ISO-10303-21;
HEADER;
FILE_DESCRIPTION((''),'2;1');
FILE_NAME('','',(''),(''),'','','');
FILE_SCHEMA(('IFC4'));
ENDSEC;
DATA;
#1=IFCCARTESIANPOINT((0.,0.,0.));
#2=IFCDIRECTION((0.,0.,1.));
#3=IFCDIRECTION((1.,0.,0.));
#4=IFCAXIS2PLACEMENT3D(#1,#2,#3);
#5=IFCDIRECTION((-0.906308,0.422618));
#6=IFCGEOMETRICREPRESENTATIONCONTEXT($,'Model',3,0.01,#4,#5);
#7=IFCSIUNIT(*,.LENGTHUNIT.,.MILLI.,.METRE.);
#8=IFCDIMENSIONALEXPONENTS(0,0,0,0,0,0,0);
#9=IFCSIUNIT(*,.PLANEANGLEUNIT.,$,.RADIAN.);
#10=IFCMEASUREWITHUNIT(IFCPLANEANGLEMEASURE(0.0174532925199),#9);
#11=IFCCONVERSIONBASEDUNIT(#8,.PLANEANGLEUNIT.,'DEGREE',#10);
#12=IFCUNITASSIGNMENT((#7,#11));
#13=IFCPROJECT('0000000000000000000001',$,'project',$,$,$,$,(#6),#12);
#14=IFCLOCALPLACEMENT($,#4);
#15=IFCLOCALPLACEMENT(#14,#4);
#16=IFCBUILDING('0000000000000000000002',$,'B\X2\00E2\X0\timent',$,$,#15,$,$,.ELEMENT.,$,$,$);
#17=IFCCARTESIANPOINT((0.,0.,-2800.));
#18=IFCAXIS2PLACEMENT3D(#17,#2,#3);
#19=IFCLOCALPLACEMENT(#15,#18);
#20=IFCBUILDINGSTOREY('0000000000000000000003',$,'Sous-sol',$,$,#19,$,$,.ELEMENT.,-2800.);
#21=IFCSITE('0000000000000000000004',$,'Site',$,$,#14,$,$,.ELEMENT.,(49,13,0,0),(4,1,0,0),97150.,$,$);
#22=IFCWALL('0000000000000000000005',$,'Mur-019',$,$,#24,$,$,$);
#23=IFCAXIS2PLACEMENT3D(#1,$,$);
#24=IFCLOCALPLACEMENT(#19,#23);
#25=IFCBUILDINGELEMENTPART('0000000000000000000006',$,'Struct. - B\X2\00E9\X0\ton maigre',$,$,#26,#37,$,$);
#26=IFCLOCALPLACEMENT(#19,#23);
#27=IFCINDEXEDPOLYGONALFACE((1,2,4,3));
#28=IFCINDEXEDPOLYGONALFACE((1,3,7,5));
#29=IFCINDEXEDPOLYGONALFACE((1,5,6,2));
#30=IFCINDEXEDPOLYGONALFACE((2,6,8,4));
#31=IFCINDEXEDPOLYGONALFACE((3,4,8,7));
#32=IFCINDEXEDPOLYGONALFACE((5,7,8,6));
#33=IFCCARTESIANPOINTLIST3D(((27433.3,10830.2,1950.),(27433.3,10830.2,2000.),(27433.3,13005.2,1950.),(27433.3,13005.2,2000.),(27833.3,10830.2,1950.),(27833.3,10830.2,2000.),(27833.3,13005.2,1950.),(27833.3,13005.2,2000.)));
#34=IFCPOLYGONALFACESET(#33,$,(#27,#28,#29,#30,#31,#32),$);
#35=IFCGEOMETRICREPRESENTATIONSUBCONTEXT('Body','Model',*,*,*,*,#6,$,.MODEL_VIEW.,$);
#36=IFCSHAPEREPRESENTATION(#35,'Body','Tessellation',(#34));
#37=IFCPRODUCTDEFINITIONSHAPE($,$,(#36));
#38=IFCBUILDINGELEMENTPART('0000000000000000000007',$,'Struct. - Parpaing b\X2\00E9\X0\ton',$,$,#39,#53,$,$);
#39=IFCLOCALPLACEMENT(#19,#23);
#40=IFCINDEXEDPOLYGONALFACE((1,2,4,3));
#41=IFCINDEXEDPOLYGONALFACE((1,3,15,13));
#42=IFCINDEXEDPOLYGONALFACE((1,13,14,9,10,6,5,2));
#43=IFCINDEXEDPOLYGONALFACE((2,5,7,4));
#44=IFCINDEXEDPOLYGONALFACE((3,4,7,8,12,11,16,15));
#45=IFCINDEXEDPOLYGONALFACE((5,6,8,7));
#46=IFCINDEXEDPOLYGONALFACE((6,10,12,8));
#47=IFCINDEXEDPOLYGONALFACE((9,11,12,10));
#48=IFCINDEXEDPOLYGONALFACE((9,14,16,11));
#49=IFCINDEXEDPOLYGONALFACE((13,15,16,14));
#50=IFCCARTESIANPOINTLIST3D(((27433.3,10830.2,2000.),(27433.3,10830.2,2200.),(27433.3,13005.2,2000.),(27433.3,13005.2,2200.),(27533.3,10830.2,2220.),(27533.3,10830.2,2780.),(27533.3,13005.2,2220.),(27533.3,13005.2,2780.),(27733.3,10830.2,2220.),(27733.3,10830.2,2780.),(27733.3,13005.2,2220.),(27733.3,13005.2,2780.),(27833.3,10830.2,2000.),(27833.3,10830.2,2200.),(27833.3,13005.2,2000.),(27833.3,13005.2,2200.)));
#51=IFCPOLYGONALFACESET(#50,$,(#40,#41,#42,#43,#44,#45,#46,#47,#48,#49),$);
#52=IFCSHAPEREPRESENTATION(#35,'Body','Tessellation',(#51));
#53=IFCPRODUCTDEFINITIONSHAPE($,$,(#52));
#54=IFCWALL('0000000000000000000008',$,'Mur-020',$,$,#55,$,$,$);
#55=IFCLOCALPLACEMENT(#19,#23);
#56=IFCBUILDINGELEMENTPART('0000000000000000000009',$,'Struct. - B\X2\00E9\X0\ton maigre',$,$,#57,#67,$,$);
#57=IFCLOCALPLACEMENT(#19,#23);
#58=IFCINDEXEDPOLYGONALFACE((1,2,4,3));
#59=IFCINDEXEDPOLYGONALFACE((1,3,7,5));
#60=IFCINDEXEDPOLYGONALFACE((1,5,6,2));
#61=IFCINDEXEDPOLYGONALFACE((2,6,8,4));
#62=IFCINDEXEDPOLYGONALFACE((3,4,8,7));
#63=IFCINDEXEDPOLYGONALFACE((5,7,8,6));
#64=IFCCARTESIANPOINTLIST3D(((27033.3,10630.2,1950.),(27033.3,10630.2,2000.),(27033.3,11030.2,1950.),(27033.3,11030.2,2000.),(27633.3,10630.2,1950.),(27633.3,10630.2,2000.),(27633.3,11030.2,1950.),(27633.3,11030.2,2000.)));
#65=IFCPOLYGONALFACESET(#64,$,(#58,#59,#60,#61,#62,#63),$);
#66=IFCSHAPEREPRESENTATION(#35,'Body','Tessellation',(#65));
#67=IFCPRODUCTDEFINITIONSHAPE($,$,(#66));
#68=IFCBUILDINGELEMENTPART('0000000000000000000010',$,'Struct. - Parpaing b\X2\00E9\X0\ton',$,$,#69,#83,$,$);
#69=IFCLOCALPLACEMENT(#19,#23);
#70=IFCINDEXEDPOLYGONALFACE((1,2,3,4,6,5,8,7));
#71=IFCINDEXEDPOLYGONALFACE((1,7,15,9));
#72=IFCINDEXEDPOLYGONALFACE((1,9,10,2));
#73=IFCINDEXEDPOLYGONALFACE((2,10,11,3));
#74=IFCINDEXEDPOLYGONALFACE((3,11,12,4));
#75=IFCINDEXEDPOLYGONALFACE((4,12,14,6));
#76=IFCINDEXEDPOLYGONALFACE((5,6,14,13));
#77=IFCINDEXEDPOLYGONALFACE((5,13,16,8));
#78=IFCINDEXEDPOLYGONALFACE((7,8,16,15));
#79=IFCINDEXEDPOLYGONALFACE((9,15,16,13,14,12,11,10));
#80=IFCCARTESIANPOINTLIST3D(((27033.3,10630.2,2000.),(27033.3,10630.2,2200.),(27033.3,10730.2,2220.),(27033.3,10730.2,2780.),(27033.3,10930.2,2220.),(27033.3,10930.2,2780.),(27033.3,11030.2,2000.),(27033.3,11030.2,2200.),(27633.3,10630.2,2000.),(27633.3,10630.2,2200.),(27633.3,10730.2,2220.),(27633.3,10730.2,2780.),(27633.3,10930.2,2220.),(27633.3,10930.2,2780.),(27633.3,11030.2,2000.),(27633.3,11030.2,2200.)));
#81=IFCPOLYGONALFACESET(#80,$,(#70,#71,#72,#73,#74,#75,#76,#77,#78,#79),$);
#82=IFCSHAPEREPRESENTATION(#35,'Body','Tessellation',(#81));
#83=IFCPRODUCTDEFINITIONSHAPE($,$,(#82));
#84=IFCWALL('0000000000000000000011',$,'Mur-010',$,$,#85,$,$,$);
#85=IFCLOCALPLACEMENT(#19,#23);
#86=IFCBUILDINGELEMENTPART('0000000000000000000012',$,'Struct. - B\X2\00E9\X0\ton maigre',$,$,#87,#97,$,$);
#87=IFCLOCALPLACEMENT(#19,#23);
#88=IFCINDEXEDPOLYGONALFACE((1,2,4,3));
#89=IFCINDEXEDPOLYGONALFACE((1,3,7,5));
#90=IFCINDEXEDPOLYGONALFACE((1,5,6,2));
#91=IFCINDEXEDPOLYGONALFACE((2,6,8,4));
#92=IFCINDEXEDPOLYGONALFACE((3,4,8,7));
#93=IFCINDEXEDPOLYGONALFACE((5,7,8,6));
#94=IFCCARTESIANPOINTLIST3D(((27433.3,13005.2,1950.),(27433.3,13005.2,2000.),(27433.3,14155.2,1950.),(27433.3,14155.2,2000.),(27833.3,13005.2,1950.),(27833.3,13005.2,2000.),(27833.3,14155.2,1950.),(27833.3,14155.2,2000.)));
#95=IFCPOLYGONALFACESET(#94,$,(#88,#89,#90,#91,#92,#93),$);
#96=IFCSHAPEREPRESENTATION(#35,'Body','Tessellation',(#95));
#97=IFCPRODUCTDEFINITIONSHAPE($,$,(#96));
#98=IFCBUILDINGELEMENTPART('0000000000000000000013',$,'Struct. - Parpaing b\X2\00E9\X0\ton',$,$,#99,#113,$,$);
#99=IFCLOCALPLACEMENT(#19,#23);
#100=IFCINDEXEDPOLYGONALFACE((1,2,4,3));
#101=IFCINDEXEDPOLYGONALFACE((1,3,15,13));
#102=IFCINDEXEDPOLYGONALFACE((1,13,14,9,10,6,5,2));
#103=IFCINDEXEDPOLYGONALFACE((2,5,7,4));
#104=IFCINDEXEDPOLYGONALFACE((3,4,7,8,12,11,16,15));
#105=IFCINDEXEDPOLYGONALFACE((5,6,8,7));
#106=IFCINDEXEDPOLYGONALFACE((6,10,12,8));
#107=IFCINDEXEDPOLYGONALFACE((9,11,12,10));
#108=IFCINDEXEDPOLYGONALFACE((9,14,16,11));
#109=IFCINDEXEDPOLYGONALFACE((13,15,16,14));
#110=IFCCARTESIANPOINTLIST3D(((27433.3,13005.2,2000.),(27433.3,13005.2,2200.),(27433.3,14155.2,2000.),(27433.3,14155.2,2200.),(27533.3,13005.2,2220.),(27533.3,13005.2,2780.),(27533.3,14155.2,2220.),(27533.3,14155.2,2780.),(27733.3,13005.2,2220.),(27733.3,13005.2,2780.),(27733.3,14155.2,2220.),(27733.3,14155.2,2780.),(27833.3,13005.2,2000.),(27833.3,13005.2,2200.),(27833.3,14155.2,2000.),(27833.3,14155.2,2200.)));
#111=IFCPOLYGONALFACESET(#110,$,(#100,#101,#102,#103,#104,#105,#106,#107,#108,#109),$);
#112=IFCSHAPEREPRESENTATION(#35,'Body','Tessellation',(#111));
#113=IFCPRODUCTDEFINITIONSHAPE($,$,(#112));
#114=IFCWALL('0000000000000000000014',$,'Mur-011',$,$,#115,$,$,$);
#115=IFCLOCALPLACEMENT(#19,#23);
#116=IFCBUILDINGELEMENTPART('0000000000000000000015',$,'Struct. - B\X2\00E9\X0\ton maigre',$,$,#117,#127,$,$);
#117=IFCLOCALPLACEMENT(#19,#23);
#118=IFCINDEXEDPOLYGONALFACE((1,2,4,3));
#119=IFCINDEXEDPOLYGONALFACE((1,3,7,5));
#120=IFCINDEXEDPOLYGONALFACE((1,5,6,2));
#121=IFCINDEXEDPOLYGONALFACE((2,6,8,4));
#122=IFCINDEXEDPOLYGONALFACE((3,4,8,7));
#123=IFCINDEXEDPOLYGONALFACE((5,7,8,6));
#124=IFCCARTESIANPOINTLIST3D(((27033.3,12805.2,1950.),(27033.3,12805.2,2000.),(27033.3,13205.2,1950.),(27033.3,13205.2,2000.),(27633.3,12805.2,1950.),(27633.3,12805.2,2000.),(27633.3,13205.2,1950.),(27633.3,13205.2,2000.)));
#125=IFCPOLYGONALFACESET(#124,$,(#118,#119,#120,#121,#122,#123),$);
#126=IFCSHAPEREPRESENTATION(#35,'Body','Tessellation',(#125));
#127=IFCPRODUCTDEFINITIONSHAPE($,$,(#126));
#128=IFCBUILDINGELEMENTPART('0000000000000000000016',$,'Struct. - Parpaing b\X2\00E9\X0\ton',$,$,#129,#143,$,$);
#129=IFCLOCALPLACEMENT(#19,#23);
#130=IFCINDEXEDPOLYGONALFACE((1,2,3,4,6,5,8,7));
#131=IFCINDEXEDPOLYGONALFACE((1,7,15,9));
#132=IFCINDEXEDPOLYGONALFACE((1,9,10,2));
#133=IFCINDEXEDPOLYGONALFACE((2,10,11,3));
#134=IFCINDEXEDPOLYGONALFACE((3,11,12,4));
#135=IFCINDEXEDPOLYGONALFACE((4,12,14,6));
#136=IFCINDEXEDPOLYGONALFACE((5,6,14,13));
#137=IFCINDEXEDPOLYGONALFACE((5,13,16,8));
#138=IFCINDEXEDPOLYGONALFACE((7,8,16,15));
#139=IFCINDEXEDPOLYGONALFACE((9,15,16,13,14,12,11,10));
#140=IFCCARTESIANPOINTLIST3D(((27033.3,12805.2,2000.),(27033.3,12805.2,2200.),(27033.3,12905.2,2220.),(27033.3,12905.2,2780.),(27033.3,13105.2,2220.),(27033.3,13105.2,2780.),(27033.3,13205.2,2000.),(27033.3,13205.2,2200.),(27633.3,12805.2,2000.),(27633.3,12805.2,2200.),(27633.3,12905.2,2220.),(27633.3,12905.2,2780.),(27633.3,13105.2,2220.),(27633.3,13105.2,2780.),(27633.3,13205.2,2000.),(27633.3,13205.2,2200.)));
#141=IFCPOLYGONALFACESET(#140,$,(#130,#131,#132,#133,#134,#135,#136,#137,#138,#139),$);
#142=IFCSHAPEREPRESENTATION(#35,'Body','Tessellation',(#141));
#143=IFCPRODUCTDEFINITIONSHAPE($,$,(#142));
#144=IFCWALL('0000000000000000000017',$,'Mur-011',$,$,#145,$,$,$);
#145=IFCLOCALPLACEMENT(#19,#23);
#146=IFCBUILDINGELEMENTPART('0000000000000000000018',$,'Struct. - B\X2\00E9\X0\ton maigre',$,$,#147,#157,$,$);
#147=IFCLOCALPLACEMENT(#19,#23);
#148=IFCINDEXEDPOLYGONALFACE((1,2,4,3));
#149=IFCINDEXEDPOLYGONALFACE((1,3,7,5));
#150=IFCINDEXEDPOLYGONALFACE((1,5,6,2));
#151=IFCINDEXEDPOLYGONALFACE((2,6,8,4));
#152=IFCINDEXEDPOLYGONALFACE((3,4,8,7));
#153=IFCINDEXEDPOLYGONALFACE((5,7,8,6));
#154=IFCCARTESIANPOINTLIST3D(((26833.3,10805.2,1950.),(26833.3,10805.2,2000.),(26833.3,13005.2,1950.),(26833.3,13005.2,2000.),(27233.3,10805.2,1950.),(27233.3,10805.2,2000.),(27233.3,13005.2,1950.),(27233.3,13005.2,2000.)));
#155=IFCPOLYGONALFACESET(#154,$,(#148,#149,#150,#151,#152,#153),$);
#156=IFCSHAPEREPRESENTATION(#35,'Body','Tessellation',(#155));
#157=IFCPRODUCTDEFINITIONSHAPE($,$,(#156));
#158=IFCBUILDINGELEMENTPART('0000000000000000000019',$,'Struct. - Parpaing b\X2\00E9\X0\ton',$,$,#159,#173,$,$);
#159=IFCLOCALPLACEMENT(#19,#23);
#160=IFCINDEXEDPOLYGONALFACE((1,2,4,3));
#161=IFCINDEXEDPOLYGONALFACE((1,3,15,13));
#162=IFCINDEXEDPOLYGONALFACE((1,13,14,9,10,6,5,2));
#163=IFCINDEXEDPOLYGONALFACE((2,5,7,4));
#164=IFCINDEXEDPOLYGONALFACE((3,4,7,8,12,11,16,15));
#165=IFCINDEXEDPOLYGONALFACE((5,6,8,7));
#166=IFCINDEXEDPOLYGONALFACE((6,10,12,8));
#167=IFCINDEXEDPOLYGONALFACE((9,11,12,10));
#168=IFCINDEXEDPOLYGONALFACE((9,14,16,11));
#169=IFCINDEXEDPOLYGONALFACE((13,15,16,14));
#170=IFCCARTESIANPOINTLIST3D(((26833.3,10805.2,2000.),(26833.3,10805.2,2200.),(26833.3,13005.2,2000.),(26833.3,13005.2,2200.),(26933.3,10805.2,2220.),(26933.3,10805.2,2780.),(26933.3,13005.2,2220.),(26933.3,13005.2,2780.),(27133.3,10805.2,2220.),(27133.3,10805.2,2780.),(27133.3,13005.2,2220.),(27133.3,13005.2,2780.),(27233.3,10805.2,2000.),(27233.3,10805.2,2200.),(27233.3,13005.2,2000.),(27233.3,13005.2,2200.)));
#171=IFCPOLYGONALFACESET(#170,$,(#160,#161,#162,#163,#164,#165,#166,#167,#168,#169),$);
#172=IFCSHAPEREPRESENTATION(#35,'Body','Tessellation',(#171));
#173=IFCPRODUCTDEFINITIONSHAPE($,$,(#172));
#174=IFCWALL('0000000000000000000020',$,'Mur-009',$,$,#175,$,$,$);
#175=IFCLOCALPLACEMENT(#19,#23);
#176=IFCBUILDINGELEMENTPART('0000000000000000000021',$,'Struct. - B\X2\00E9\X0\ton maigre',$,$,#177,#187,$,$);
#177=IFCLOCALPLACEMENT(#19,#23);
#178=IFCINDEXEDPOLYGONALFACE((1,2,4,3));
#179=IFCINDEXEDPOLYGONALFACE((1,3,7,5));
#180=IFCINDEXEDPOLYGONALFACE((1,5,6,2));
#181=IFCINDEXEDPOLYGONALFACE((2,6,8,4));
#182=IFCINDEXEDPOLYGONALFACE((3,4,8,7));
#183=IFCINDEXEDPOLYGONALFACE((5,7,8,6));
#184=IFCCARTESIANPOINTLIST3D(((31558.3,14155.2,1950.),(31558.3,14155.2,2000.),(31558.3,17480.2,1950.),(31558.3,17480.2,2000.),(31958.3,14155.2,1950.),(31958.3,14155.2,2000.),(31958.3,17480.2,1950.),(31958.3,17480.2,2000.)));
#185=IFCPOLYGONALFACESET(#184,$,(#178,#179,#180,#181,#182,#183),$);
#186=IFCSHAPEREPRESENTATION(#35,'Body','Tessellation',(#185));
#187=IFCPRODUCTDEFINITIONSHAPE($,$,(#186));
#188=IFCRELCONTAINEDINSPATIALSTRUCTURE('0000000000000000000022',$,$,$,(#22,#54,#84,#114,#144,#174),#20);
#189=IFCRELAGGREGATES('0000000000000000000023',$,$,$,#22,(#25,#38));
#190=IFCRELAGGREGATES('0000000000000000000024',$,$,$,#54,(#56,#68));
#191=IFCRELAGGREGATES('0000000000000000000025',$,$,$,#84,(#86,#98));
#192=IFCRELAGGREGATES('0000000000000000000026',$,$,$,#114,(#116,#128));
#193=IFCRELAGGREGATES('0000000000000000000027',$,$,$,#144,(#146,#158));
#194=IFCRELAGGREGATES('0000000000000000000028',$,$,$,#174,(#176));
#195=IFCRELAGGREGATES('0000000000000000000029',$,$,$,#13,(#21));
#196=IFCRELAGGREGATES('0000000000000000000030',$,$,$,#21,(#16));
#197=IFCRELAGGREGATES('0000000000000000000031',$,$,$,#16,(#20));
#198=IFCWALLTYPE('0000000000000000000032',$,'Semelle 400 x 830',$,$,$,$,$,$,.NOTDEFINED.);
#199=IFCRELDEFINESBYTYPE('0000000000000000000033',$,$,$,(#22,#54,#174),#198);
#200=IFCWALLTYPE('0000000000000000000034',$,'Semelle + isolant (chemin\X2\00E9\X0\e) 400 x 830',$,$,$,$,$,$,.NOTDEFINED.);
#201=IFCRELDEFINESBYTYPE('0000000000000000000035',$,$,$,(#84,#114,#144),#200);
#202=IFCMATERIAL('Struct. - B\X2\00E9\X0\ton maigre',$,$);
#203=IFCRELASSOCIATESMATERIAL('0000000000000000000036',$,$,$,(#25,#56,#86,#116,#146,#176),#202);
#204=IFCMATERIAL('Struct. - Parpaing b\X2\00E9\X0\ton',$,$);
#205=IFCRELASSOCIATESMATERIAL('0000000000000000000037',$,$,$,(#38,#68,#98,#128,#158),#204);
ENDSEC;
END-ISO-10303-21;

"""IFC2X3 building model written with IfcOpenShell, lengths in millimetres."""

from ifc_helpers import new_model, entity, si_unit, converted_unit, direction, frame, origin_with_axes, place, context, subcontext, project, spatial, polyline, outline, extrude, material, type_object, element, aggregate, save


model = new_model("IFC2X3")

# Units and contexts
model_context = context("Model", 3, precision=0.01, world=origin_with_axes(), true_north=direction((-0.906308, 0.422618)))
body_context = subcontext(model_context, "Body", "Model", "MODEL_VIEW")
ifc_project = project(units=[si_unit("LENGTHUNIT", "METRE", prefix="MILLI"), converted_unit("PLANEANGLEUNIT", "DEGREE", entity("IfcPlaneAngleMeasure", 0.0174532925199), si_unit("PLANEANGLEUNIT", "RADIAN"), dimensions=[0, 0, 0, 0, 0, 0, 0])], contexts=[model_context])

# Site, building, storey
site_placement = place(None, origin_with_axes())
site = spatial("IfcSite", under=ifc_project, at=site_placement, Name="Site", CompositionType="ELEMENT", RefLatitude=(49, 13, 0, 0), RefLongitude=(4, 1, 0, 0), RefElevation=97150.0)
building_placement = place(site_placement, origin_with_axes())
building = spatial("IfcBuilding", under=site, at=building_placement, Name="Bâtiment", CompositionType="ELEMENT")
storey_placement = place(building_placement, frame((0.0, 0.0, -2800.0), z_axis=(0.0, 0.0, 1.0), x_axis=(1.0, 0.0, 0.0)))
storey = spatial("IfcBuildingStorey", under=building, at=storey_placement, Name="Sous-sol", CompositionType="ELEMENT", Elevation=-2800.0)

# Walls, building element parts
wall_type_1 = type_object("IfcWallType", Name="Semelle 400 x 830", PredefinedType="NOTDEFINED")
wall_1_placement = place(storey_placement, frame((27633.3, 13005.2, 2000.0), z_axis=(0.0, 0.0, 1.0), x_axis=(0.0, -1.0, 0.0)))
wall_1 = element("IfcWall", 1, at=wall_1_placement, inside=storey, type_object=wall_type_1, Name="Mur-019")
ifc_material_1 = material(Name="Struct. - Béton maigre")
building_element_part_1_placement = place(wall_1_placement, origin_with_axes())
building_element_part_1 = element("IfcBuildingElementPart", 2, at=building_element_part_1_placement, material=ifc_material_1, Name="Struct. - Béton maigre", context=body_context, shape_type="SweptSolid", body=[
    extrude(outline(polyline([(-200.0, 0.0), (-200.0, -50.0), (200.0, -50.0), (200.0, 0.0), (-200.0, 0.0)])), frame((0.0, 0.0, 0.0), z_axis=(-1.0, 0.0, 0.0), x_axis=(0.0, -1.0, 0.0)), (0.0, 0.0, -1.0), 2175.0),
])
ifc_material_2 = material(Name="Struct. - Parpaing béton")
building_element_part_2_placement = place(wall_1_placement, origin_with_axes())
building_element_part_2 = element("IfcBuildingElementPart", 3, at=building_element_part_2_placement, material=ifc_material_2, Name="Struct. - Parpaing béton", context=body_context, shape_type="SweptSolid", body=[
    extrude(outline(polyline([(-200.0, 200.0), (-200.0, 0.0), (200.0, 0.0), (200.0, 200.0), (100.0, 220.0), (100.0, 780.0), (-100.0, 780.0), (-100.0, 220.0), (-200.0, 200.0)])), frame((0.0, 0.0, 0.0), z_axis=(-1.0, 0.0, 0.0), x_axis=(0.0, -1.0, 0.0)), (0.0, 0.0, -1.0), 2175.0),
])
aggregate(wall_1, [building_element_part_1, building_element_part_2])
wall_2_placement = place(storey_placement, frame((27633.3, 10830.2, 2000.0), z_axis=(0.0, 0.0, 1.0), x_axis=(-1.0, 0.0, 0.0)))
wall_2 = element("IfcWall", 4, at=wall_2_placement, inside=storey, type_object=wall_type_1, Name="Mur-020")
building_element_part_3_placement = place(wall_2_placement, origin_with_axes())
building_element_part_3 = element("IfcBuildingElementPart", 5, at=building_element_part_3_placement, material=ifc_material_1, Name="Struct. - Béton maigre", context=body_context, shape_type="SweptSolid", body=[
    extrude(outline(polyline([(-200.0, 0.0), (-200.0, -50.0), (200.0, -50.0), (200.0, 0.0), (-200.0, 0.0)])), frame((0.0, 0.0, 0.0), z_axis=(-1.0, 0.0, 0.0), x_axis=(0.0, -1.0, 0.0)), (0.0, 0.0, -1.0), 600.0),
])
building_element_part_4_placement = place(wall_2_placement, origin_with_axes())
building_element_part_4 = element("IfcBuildingElementPart", 6, at=building_element_part_4_placement, material=ifc_material_2, Name="Struct. - Parpaing béton", context=body_context, shape_type="SweptSolid", body=[
    extrude(outline(polyline([(-200.0, 200.0), (-200.0, 0.0), (200.0, 0.0), (200.0, 200.0), (100.0, 220.0), (100.0, 780.0), (-100.0, 780.0), (-100.0, 220.0), (-200.0, 200.0)])), frame((0.0, 0.0, 0.0), z_axis=(-1.0, 0.0, 0.0), x_axis=(0.0, -1.0, 0.0)), (0.0, 0.0, -1.0), 600.0),
])
aggregate(wall_2, [building_element_part_3, building_element_part_4])
wall_type_2 = type_object("IfcWallType", Name="Semelle + isolant (cheminée) 400 x 830", PredefinedType="NOTDEFINED")
wall_3_placement = place(storey_placement, frame((27633.3, 14155.2, 2000.0), z_axis=(0.0, 0.0, 1.0), x_axis=(0.0, -1.0, 0.0)))
wall_3 = element("IfcWall", 7, at=wall_3_placement, inside=storey, type_object=wall_type_2, Name="Mur-010")
building_element_part_5_placement = place(wall_3_placement, origin_with_axes())
building_element_part_5 = element("IfcBuildingElementPart", 8, at=building_element_part_5_placement, material=ifc_material_1, Name="Struct. - Béton maigre", context=body_context, shape_type="SweptSolid", body=[
    extrude(outline(polyline([(-200.0, 0.0), (-200.0, -50.0), (200.0, -50.0), (200.0, 0.0), (-200.0, 0.0)])), frame((0.0, 0.0, 0.0), z_axis=(-1.0, 0.0, 0.0), x_axis=(0.0, -1.0, 0.0)), (0.0, 0.0, -1.0), 1150.0),
])
building_element_part_6_placement = place(wall_3_placement, origin_with_axes())
building_element_part_6 = element("IfcBuildingElementPart", 9, at=building_element_part_6_placement, material=ifc_material_2, Name="Struct. - Parpaing béton", context=body_context, shape_type="SweptSolid", body=[
    extrude(outline(polyline([(-100.0, 220.0), (-200.0, 200.0), (-200.0, 0.0), (200.0, 0.0), (200.0, 200.0), (100.0, 220.0), (100.0, 780.0), (-100.0, 780.0), (-100.0, 220.0)])), frame((0.0, 0.0, 0.0), z_axis=(-1.0, 0.0, 0.0), x_axis=(0.0, -1.0, 0.0)), (0.0, 0.0, -1.0), 1150.0),
])
aggregate(wall_3, [building_element_part_5, building_element_part_6])
wall_4_placement = place(storey_placement, frame((27633.3, 13005.2, 2000.0), z_axis=(0.0, 0.0, 1.0), x_axis=(-1.0, 0.0, 0.0)))
wall_4 = element("IfcWall", 10, at=wall_4_placement, inside=storey, type_object=wall_type_2, Name="Mur-011")
building_element_part_7_placement = place(wall_4_placement, origin_with_axes())
building_element_part_7 = element("IfcBuildingElementPart", 11, at=building_element_part_7_placement, material=ifc_material_1, Name="Struct. - Béton maigre", context=body_context, shape_type="SweptSolid", body=[
    extrude(outline(polyline([(-200.0, 0.0), (-200.0, -50.0), (200.0, -50.0), (200.0, 0.0), (-200.0, 0.0)])), frame((0.0, 0.0, 0.0), z_axis=(-1.0, 0.0, 0.0), x_axis=(0.0, -1.0, 0.0)), (0.0, 0.0, -1.0), 600.0),
])
building_element_part_8_placement = place(wall_4_placement, origin_with_axes())
building_element_part_8 = element("IfcBuildingElementPart", 12, at=building_element_part_8_placement, material=ifc_material_2, Name="Struct. - Parpaing béton", context=body_context, shape_type="SweptSolid", body=[
    extrude(outline(polyline([(-100.0, 220.0), (-200.0, 200.0), (-200.0, 0.0), (200.0, 0.0), (200.0, 200.0), (100.0, 220.0), (100.0, 780.0), (-100.0, 780.0), (-100.0, 220.0)])), frame((0.0, 0.0, 0.0), z_axis=(-1.0, 0.0, 0.0), x_axis=(0.0, -1.0, 0.0)), (0.0, 0.0, -1.0), 600.0),
])
aggregate(wall_4, [building_element_part_7, building_element_part_8])
wall_5_placement = place(storey_placement, frame((27033.3, 13005.2, 2000.0), z_axis=(0.0, 0.0, 1.0), x_axis=(0.0, -1.0, 0.0)))
wall_5 = element("IfcWall", 13, at=wall_5_placement, inside=storey, type_object=wall_type_2, Name="Mur-011")
building_element_part_9_placement = place(wall_5_placement, origin_with_axes())
building_element_part_9 = element("IfcBuildingElementPart", 14, at=building_element_part_9_placement, material=ifc_material_1, Name="Struct. - Béton maigre", context=body_context, shape_type="SweptSolid", body=[
    extrude(outline(polyline([(-200.0, 0.0), (-200.0, -50.0), (200.0, -50.0), (200.0, 0.0), (-200.0, 0.0)])), frame((0.0, 0.0, 0.0), z_axis=(-1.0, 0.0, 0.0), x_axis=(0.0, -1.0, 0.0)), (0.0, 0.0, -1.0), 2200.0),
])
building_element_part_10_placement = place(wall_5_placement, origin_with_axes())
building_element_part_10 = element("IfcBuildingElementPart", 15, at=building_element_part_10_placement, material=ifc_material_2, Name="Struct. - Parpaing béton", context=body_context, shape_type="SweptSolid", body=[
    extrude(outline(polyline([(-100.0, 220.0), (-200.0, 200.0), (-200.0, 0.0), (200.0, 0.0), (200.0, 200.0), (100.0, 220.0), (100.0, 780.0), (-100.0, 780.0), (-100.0, 220.0)])), frame((0.0, 0.0, 0.0), z_axis=(-1.0, 0.0, 0.0), x_axis=(0.0, -1.0, 0.0)), (0.0, 0.0, -1.0), 2200.0),
])
aggregate(wall_5, [building_element_part_9, building_element_part_10])
wall_6_placement = place(storey_placement, frame((31758.3, 14155.2, 2000.0), z_axis=(0.0, 0.0, 1.0), x_axis=(0.0, 1.0, 0.0)))
wall_6 = element("IfcWall", 16, at=wall_6_placement, inside=storey, type_object=wall_type_1, Name="Mur-009")
building_element_part_11_placement = place(wall_6_placement, origin_with_axes())
building_element_part_11 = element("IfcBuildingElementPart", 17, at=building_element_part_11_placement, material=ifc_material_1, Name="Struct. - Béton maigre", context=body_context, shape_type="SweptSolid", body=[
    extrude(outline(polyline([(-200.0, 0.0), (-200.0, -50.0), (200.0, -50.0), (200.0, 0.0), (-200.0, 0.0)])), frame((0.0, 0.0, 0.0), z_axis=(-1.0, 0.0, 0.0), x_axis=(0.0, -1.0, 0.0)), (0.0, 0.0, -1.0), 3325.0),
])
aggregate(wall_6, [building_element_part_11])

save(model, "model.ifc")
